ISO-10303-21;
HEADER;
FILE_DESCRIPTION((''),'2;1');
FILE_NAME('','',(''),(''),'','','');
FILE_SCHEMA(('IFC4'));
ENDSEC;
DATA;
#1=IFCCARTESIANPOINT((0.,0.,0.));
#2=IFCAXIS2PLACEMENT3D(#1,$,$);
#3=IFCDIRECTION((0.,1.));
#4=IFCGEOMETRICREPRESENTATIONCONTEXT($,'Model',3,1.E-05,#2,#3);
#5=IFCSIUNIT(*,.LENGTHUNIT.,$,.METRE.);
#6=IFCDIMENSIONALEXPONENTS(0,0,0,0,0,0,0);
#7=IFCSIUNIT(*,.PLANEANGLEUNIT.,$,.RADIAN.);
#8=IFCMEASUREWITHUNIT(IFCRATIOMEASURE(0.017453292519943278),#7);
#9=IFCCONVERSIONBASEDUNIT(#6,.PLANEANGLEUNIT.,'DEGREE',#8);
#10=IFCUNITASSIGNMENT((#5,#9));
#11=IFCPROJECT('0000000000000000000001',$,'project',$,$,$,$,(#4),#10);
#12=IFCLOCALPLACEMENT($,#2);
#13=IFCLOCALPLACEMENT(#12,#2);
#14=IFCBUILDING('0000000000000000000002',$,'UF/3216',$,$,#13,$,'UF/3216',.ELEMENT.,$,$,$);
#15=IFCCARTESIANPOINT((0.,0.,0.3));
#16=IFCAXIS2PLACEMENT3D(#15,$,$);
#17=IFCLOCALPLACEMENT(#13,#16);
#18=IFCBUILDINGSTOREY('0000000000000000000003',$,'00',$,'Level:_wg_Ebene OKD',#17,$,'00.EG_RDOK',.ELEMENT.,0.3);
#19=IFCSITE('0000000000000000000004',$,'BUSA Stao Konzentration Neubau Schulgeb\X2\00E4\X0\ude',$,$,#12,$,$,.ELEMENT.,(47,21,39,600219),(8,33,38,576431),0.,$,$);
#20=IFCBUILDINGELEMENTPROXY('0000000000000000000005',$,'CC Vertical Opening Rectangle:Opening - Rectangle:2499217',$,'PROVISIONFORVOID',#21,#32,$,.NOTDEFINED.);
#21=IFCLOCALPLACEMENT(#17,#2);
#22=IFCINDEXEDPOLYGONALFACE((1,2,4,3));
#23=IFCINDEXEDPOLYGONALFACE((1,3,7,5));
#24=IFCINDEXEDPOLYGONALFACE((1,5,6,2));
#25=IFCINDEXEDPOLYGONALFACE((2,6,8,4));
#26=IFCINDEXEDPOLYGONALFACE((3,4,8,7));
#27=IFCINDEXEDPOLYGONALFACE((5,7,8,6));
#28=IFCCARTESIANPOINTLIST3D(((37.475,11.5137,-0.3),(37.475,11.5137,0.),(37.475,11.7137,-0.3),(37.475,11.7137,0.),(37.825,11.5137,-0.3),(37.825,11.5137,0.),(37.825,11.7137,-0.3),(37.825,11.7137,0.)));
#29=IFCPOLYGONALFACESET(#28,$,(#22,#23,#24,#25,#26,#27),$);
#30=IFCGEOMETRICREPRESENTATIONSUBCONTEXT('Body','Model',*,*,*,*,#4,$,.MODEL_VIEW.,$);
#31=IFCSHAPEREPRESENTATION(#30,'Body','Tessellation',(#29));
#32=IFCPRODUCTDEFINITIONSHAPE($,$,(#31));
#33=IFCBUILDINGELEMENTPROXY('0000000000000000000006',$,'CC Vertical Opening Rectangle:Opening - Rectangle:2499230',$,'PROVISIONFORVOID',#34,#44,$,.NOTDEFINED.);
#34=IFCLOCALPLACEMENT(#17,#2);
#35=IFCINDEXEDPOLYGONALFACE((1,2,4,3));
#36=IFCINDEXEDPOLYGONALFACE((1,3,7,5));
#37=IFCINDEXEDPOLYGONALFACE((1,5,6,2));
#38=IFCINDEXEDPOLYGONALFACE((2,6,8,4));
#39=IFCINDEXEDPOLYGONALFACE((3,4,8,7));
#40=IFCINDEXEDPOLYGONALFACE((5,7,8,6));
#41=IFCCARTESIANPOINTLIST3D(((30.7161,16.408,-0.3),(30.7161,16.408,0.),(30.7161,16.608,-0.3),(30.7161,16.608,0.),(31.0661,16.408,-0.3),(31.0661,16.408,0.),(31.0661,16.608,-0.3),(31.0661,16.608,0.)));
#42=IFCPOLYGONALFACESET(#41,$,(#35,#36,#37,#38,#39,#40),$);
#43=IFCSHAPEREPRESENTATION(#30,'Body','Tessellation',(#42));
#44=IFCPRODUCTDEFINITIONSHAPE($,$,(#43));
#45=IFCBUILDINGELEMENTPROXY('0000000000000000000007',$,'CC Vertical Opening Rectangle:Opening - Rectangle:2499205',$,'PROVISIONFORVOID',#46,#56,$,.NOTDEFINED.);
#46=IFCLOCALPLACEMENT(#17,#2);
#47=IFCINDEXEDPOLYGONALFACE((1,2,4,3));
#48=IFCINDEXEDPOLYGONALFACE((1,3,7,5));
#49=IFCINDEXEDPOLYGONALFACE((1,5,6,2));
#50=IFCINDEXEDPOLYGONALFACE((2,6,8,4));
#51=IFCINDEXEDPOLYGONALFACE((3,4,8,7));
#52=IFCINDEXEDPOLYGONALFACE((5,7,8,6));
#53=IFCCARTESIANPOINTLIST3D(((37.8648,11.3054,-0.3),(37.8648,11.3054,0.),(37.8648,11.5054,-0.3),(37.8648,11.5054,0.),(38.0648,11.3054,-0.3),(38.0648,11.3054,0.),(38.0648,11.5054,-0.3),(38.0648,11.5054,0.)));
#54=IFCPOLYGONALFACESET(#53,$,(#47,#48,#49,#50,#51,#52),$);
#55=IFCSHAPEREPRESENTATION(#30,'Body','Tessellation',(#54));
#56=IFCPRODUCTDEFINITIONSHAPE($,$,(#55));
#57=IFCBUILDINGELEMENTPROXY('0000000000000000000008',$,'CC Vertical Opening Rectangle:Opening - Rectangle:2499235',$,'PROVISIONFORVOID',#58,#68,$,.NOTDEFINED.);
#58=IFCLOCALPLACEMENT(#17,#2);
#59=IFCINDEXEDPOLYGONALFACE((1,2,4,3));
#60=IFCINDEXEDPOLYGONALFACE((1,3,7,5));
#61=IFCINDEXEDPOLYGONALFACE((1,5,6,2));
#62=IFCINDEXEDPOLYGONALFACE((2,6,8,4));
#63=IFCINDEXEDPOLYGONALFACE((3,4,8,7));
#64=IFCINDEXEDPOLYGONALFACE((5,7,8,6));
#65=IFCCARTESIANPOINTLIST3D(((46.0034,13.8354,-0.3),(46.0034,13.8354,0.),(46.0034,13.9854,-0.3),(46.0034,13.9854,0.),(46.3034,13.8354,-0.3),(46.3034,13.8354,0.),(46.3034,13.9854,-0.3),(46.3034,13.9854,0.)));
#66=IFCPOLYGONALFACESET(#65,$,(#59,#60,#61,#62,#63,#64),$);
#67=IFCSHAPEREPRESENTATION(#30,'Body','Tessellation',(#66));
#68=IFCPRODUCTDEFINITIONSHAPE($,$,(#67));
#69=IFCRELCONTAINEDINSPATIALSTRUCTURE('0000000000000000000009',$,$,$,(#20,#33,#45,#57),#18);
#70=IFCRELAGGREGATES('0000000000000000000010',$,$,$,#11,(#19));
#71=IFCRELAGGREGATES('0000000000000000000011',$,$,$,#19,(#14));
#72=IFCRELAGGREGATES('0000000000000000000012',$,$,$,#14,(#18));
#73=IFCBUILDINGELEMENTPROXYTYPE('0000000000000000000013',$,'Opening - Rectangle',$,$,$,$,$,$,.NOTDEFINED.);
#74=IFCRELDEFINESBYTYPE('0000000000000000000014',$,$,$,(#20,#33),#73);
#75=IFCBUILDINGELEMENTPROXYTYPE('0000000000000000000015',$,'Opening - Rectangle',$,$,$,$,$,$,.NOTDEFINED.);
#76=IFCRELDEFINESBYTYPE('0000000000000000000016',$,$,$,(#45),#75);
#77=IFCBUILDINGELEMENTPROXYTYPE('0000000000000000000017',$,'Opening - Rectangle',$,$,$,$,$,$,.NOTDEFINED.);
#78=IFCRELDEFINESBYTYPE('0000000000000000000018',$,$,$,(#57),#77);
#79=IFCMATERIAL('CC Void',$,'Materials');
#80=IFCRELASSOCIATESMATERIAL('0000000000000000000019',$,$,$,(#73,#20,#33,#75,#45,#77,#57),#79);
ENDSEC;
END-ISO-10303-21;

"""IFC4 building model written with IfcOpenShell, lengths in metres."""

from ifc_helpers import new_model, entity, si_unit, converted_unit, direction, frame, origin, place, context, subcontext, project, spatial, indexed_curve, outline, extrude, source, transform, mapped, material, type_object, type_shapes, element, save


model = new_model("IFC4")

# Units and contexts
model_context = context("Model", 3, precision=1e-05, world=origin(), true_north=direction((0.0, 1.0)))
body_context = subcontext(model_context, "Body", "Model", "MODEL_VIEW")
ifc_project = project(units=[si_unit("LENGTHUNIT", "METRE"), converted_unit("PLANEANGLEUNIT", "DEGREE", entity("IfcRatioMeasure", 0.017453292519943278), si_unit("PLANEANGLEUNIT", "RADIAN"), dimensions=[0, 0, 0, 0, 0, 0, 0])], contexts=[model_context])

# Site, building, storey
site_placement = place(None, origin())
site = spatial("IfcSite", under=ifc_project, at=site_placement, Name="BUSA Stao Konzentration Neubau Schulgebäude", CompositionType="ELEMENT", RefLatitude=(47, 21, 39, 600219), RefLongitude=(8, 33, 38, 576431), RefElevation=0.0)
building_placement = place(site_placement, origin())
building = spatial("IfcBuilding", under=site, at=building_placement, Name="UF/3216", LongName="UF/3216", CompositionType="ELEMENT")
storey_placement = place(building_placement, frame((0.0, 0.0, 0.3)))
storey = spatial("IfcBuildingStorey", under=building, at=storey_placement, Name="00", ObjectType="Level:_wg_Ebene OKD", LongName="00.EG_RDOK", CompositionType="ELEMENT", Elevation=0.3)

# Building element proxies
ifc_material_1 = material(Name="CC Void", Category="Materials")
building_element_proxy_type_1 = type_object("IfcBuildingElementProxyType", Name="Opening - Rectangle", PredefinedType="NOTDEFINED", material=ifc_material_1)
shared_shape_1 = source(origin(), body_context, "Body", "SweptSolid", [
    extrude(outline(indexed_curve([(-0.175, -0.1), (0.175, -0.1), (0.175, 0.1), (-0.175, 0.1), (-0.175, -0.1)], self_intersect=False)), frame((0.0, 0.0, 0.0), z_axis=(0.0, 0.0, 1.0), x_axis=(0.0, 1.0, 0.0)), (0.0, 0.0, 1.0), 0.3),
])
type_shapes(building_element_proxy_type_1, [shared_shape_1])
for number, where, z_axis, x_axis, name in (
    (1, (37.65, 11.6137, -0.3), (0.0, 0.0, 1.0), (0.0, -1.0, 0.0), "CC Vertical Opening Rectangle:Opening - Rectangle:2499217"),
    (2, (30.8911, 16.508, -0.3), (0.0, 0.0, 1.0), (0.0, -1.0, 0.0), "CC Vertical Opening Rectangle:Opening - Rectangle:2499230"),
):
    element("IfcBuildingElementProxy", number, at=place(storey_placement, frame(where, z_axis=z_axis, x_axis=x_axis)), inside=storey, type_object=building_element_proxy_type_1, material=ifc_material_1, Name=name, ObjectType="PROVISIONFORVOID", PredefinedType="NOTDEFINED", context=body_context, shape_type="MappedRepresentation", body=[
        mapped(shared_shape_1, transform((0.0, 0.0, 0.0), scale=1.0)),
    ])
building_element_proxy_type_2 = type_object("IfcBuildingElementProxyType", Name="Opening - Rectangle", PredefinedType="NOTDEFINED", material=ifc_material_1)
shared_shape_2 = source(origin(), body_context, "Body", "SweptSolid", [
    extrude(outline(indexed_curve([(-0.1, -0.1), (0.1, -0.1), (0.1, 0.1), (-0.1, 0.1), (-0.1, -0.1)], self_intersect=False)), frame((0.0, 0.0, 0.0), z_axis=(0.0, 0.0, 1.0), x_axis=(0.0, 1.0, 0.0)), (0.0, 0.0, 1.0), 0.3),
])
type_shapes(building_element_proxy_type_2, [shared_shape_2])
proxy_1_placement = place(storey_placement, frame((37.9648, 11.4054, -0.3), z_axis=(0.0, 0.0, 1.0), x_axis=(0.0, -1.0, 0.0)))
element("IfcBuildingElementProxy", 3, at=proxy_1_placement, inside=storey, type_object=building_element_proxy_type_2, material=ifc_material_1, Name="CC Vertical Opening Rectangle:Opening - Rectangle:2499205", ObjectType="PROVISIONFORVOID", PredefinedType="NOTDEFINED", context=body_context, shape_type="MappedRepresentation", body=[
    mapped(shared_shape_2, transform((0.0, 0.0, 0.0), scale=1.0)),
])
building_element_proxy_type_3 = type_object("IfcBuildingElementProxyType", Name="Opening - Rectangle", PredefinedType="NOTDEFINED", material=ifc_material_1)
shared_shape_3 = source(origin(), body_context, "Body", "SweptSolid", [
    extrude(outline(indexed_curve([(-0.15, -0.075), (0.15, -0.075), (0.15, 0.075), (-0.15, 0.075), (-0.15, -0.075)], self_intersect=False)), frame((0.0, 0.0, 0.0), z_axis=(0.0, 0.0, 1.0), x_axis=(0.0, 1.0, 0.0)), (0.0, 0.0, 1.0), 0.3),
])
type_shapes(building_element_proxy_type_3, [shared_shape_3])
proxy_2_placement = place(storey_placement, frame((46.1534, 13.9104, -0.3), z_axis=(0.0, 0.0, 1.0), x_axis=(0.0, -1.0, 0.0)))
element("IfcBuildingElementProxy", 4, at=proxy_2_placement, inside=storey, type_object=building_element_proxy_type_3, material=ifc_material_1, Name="CC Vertical Opening Rectangle:Opening - Rectangle:2499235", ObjectType="PROVISIONFORVOID", PredefinedType="NOTDEFINED", context=body_context, shape_type="MappedRepresentation", body=[
    mapped(shared_shape_3, transform((0.0, 0.0, 0.0), scale=1.0)),
])

save(model, "model.ifc")
